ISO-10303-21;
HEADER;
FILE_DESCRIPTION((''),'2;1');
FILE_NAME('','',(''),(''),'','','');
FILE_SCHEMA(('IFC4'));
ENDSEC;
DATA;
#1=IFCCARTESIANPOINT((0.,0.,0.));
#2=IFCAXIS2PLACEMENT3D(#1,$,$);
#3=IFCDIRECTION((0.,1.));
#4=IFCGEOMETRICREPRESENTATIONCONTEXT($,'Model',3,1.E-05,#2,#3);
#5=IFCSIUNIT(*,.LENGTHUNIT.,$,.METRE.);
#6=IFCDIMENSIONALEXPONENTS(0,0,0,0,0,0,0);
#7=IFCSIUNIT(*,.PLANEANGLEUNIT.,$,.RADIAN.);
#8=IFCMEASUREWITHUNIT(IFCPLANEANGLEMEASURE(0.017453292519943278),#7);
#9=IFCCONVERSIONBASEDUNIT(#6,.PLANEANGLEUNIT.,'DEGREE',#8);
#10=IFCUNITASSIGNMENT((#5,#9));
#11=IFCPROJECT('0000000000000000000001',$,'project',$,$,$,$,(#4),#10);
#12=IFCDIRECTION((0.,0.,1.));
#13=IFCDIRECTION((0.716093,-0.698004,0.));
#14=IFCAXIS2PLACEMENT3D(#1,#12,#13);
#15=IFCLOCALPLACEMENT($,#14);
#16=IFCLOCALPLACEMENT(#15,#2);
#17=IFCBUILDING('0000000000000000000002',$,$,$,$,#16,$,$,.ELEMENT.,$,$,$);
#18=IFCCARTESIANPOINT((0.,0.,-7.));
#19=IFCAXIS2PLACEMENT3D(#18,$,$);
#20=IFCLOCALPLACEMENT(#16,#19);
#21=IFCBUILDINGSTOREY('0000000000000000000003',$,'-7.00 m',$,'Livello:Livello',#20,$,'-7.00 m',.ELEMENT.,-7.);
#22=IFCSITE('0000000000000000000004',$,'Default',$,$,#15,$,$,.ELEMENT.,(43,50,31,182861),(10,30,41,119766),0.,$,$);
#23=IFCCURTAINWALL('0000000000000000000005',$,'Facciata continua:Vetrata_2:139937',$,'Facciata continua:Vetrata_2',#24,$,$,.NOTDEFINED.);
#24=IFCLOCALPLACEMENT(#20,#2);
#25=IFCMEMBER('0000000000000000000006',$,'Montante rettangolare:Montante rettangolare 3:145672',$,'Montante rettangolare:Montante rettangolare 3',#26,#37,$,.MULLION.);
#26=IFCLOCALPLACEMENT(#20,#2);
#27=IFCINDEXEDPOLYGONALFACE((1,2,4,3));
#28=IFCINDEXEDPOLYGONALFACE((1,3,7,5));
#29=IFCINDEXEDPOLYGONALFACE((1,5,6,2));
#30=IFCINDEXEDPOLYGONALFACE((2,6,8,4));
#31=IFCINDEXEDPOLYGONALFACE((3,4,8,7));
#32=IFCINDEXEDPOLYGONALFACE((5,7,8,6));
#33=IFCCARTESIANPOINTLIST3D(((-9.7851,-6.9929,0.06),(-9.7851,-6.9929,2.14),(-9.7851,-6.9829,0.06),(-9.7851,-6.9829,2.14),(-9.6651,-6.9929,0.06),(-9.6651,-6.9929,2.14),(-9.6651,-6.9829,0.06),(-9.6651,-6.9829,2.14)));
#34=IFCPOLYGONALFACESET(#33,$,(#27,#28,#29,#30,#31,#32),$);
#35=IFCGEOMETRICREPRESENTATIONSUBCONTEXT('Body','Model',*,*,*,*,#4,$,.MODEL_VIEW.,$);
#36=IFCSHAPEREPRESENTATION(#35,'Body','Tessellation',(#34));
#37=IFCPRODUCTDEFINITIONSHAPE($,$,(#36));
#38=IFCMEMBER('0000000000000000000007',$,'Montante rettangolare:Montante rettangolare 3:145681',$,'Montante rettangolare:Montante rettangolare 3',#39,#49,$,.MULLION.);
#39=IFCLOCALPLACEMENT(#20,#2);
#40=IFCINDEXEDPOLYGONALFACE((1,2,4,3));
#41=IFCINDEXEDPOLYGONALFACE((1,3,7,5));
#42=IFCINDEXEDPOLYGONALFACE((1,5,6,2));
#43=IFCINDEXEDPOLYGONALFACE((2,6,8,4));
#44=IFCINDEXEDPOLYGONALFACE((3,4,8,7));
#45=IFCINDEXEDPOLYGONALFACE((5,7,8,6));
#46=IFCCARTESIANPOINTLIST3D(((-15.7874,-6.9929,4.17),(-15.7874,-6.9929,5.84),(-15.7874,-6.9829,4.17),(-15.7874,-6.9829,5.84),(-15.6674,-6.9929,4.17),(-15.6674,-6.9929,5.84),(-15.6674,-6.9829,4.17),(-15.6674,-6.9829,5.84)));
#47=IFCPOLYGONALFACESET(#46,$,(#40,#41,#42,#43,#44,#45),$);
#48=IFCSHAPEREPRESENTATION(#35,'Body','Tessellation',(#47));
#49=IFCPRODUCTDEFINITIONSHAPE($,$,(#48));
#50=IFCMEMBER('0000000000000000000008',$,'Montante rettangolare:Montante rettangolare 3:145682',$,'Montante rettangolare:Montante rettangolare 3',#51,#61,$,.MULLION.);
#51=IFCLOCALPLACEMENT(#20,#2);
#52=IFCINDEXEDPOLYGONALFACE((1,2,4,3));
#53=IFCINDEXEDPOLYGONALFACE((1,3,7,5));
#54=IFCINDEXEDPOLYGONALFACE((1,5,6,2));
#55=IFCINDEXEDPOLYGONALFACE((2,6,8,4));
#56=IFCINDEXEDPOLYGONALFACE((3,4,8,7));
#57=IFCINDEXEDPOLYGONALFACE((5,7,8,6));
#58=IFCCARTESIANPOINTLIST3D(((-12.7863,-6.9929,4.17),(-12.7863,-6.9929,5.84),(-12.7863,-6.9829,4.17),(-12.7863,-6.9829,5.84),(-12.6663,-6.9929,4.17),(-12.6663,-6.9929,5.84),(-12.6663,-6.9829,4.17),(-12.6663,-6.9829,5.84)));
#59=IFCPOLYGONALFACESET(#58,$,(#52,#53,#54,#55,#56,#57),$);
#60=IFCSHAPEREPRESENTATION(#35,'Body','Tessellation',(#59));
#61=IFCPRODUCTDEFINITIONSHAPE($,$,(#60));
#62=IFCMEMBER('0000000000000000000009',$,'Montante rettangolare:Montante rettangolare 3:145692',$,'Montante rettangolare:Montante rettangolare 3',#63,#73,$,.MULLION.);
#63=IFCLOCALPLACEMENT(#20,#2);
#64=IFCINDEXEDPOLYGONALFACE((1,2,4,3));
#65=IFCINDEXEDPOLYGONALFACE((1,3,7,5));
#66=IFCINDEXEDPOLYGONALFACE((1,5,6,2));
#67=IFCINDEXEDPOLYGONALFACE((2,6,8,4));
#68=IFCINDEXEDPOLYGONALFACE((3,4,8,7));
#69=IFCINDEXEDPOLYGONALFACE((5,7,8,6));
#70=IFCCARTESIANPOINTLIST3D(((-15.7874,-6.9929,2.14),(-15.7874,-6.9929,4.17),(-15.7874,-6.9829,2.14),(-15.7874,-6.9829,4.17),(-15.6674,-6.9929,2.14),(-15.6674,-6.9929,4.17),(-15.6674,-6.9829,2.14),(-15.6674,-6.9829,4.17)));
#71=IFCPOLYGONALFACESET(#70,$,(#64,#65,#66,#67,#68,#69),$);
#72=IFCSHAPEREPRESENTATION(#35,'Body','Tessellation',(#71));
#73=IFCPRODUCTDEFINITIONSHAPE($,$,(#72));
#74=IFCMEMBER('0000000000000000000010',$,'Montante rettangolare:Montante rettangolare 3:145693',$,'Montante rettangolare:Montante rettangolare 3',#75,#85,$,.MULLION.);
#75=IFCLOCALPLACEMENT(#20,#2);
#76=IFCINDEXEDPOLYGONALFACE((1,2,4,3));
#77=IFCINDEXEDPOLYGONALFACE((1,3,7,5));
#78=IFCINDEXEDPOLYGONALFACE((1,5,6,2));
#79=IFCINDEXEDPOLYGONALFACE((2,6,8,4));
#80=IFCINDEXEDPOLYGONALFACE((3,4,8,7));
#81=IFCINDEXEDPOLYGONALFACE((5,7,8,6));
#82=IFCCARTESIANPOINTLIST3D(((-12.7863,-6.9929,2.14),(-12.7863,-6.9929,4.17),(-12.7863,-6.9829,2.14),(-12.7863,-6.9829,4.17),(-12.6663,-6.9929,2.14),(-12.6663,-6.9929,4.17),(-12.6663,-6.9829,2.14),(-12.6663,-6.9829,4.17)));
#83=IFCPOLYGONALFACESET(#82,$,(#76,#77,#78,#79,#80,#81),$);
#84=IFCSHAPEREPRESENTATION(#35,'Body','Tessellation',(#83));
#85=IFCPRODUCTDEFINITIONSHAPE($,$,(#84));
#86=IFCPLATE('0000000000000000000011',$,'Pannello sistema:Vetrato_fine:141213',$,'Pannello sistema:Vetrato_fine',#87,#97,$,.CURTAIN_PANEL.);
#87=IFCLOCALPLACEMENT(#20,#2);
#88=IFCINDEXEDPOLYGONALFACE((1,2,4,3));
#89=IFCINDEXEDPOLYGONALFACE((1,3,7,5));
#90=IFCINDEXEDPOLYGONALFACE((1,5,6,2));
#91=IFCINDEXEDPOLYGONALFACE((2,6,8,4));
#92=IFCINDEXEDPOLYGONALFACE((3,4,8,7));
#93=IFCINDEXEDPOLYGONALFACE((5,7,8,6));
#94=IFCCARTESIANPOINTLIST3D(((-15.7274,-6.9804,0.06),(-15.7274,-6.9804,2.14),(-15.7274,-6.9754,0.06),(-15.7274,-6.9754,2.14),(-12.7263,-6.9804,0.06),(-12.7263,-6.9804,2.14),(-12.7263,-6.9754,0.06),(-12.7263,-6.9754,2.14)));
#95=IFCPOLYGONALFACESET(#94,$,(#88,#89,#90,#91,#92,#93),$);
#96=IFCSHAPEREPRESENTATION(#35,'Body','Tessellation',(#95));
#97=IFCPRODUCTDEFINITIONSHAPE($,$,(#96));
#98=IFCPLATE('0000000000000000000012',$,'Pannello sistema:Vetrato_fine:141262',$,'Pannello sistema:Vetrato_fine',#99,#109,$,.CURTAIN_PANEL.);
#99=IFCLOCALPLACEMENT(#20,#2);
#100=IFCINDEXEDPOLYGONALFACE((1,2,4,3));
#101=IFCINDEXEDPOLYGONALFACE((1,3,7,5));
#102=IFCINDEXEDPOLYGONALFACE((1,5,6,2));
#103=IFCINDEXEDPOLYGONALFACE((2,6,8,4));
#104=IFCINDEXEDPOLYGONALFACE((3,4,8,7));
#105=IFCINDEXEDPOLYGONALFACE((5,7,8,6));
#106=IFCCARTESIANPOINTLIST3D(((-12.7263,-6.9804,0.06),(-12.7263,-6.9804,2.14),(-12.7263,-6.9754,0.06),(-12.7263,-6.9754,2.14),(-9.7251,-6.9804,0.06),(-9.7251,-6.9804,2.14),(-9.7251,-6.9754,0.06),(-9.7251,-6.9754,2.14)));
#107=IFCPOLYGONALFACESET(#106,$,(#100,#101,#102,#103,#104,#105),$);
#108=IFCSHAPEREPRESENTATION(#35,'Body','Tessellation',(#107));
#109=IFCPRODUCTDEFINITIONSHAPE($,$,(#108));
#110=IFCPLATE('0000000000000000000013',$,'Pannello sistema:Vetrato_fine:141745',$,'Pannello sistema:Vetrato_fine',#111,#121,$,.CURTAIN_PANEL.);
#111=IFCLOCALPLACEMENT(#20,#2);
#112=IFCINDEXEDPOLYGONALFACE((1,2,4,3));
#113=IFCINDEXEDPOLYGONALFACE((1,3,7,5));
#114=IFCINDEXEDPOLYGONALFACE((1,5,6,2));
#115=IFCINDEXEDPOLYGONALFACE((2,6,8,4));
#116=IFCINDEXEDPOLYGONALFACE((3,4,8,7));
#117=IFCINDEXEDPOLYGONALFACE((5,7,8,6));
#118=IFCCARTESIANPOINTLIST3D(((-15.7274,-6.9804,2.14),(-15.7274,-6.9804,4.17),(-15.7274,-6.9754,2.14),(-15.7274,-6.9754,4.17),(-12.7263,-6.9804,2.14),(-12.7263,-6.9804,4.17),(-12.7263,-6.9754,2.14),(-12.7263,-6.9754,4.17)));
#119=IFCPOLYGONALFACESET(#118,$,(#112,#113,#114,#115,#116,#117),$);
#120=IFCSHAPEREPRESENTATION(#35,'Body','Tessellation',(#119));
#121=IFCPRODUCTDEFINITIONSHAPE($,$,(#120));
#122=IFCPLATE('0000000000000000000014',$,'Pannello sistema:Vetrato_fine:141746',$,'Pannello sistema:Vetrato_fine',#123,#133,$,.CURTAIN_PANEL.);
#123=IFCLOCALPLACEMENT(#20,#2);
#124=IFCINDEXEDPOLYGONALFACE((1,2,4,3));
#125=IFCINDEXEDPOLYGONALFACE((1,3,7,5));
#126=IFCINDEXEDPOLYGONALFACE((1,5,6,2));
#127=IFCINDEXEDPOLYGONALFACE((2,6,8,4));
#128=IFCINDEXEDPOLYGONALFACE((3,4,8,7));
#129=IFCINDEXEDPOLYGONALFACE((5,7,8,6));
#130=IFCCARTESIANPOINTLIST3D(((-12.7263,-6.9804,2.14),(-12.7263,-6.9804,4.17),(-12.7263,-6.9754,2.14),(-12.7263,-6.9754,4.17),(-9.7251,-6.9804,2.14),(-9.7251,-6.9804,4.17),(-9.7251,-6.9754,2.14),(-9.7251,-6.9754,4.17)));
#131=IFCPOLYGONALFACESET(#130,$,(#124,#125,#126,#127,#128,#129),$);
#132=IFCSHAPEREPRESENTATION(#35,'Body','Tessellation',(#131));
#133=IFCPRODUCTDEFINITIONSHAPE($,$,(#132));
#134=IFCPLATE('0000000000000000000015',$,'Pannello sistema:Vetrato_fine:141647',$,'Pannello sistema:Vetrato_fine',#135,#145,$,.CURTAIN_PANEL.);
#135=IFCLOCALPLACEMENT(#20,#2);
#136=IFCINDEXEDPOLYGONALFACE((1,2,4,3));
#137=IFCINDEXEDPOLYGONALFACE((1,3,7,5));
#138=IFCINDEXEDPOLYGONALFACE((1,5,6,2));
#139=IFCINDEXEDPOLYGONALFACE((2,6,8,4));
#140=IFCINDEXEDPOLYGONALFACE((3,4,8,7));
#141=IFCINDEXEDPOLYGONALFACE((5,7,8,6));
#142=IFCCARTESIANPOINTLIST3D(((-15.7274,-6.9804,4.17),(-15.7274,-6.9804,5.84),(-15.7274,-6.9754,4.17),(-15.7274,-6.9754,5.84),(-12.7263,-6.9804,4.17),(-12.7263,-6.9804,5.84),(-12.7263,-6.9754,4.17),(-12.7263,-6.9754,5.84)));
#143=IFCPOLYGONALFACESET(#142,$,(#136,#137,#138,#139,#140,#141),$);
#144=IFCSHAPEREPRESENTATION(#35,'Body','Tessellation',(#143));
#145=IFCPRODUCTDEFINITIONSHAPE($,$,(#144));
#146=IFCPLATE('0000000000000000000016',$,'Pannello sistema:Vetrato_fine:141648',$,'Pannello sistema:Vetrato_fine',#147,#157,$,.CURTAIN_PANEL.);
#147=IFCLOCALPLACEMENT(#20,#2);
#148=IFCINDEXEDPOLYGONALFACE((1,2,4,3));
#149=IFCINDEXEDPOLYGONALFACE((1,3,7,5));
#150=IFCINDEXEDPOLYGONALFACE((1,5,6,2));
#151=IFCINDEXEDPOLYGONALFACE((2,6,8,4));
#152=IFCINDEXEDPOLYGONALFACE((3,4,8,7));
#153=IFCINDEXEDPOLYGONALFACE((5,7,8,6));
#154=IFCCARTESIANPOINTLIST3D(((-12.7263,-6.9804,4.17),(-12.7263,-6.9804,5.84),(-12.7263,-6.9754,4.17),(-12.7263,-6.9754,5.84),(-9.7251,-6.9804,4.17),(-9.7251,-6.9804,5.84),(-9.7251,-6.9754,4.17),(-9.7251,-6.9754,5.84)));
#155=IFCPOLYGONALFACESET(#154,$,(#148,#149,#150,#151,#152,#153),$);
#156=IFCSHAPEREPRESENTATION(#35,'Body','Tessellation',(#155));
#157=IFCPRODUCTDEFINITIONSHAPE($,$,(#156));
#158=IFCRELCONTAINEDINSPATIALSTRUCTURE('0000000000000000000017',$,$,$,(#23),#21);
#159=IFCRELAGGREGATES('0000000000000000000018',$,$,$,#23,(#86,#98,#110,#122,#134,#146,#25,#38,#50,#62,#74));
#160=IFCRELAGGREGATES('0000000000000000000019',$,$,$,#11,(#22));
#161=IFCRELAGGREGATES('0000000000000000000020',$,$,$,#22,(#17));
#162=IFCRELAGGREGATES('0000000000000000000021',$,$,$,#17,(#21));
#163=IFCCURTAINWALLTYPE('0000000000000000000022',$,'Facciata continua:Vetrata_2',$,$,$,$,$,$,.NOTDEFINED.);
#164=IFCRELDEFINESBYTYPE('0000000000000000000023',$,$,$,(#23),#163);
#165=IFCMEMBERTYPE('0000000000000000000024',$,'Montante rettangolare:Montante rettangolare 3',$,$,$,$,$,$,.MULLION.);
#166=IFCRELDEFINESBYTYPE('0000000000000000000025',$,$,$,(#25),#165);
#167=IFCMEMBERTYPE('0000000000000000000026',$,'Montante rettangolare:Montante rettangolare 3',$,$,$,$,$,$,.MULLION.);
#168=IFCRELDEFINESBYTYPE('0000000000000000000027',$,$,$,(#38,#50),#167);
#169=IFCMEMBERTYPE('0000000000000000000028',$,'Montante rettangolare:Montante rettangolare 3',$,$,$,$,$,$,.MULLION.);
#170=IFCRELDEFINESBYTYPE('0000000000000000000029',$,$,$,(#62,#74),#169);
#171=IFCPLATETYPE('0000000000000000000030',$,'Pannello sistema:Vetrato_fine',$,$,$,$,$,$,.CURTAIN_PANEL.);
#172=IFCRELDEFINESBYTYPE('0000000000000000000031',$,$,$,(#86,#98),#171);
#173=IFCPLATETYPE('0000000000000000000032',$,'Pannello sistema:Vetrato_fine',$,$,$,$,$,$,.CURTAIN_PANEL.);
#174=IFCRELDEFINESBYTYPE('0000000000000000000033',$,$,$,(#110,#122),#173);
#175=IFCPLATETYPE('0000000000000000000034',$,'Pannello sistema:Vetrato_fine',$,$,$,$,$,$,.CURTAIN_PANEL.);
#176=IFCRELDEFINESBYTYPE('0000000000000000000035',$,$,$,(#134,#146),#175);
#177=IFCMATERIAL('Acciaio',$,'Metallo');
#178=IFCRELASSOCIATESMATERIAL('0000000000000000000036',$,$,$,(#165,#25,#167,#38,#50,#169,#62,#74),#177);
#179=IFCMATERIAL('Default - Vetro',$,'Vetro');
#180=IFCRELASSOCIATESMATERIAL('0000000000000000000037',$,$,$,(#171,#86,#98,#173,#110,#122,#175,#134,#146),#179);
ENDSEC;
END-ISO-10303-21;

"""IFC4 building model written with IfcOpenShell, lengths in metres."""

from ifc_helpers import new_model, entity, si_unit, converted_unit, direction, frame, origin, place, context, subcontext, project, spatial, indexed_curve, outline, extrude, source, transform, mapped, material, type_object, type_shapes, element, aggregate, save


model = new_model("IFC4")

# Units and contexts
model_context = context("Model", 3, precision=1e-05, world=origin(), true_north=direction((0.0, 1.0)))
body_context = subcontext(model_context, "Body", "Model", "MODEL_VIEW")
ifc_project = project(units=[si_unit("LENGTHUNIT", "METRE"), converted_unit("PLANEANGLEUNIT", "DEGREE", entity("IfcPlaneAngleMeasure", 0.017453292519943278), si_unit("PLANEANGLEUNIT", "RADIAN"), dimensions=[0, 0, 0, 0, 0, 0, 0])], contexts=[model_context])

# Site, building, storey
site_placement = place(None, frame((0.0, 0.0, 0.0), z_axis=(0.0, 0.0, 1.0), x_axis=(0.716093, -0.698004, 0.0)))
site = spatial("IfcSite", under=ifc_project, at=site_placement, Name="Default", CompositionType="ELEMENT", RefLatitude=(43, 50, 31, 182861), RefLongitude=(10, 30, 41, 119766), RefElevation=0.0)
building_placement = place(site_placement, origin())
building = spatial("IfcBuilding", under=site, at=building_placement, CompositionType="ELEMENT")
storey_placement = place(building_placement, frame((0.0, 0.0, -7.0)))
storey = spatial("IfcBuildingStorey", under=building, at=storey_placement, Name="-7.00 m", ObjectType="Livello:Livello", LongName="-7.00 m", CompositionType="ELEMENT", Elevation=-7.0)

# Curtain wall, members, plates
curtain_wall_type = type_object("IfcCurtainWallType", Name="Facciata continua:Vetrata_2", PredefinedType="NOTDEFINED")
curtain_wall_placement = place(storey_placement, frame((0.0, 0.0, 7.0)))
curtain_wall = element("IfcCurtainWall", 1, at=curtain_wall_placement, inside=storey, type_object=curtain_wall_type, Name="Facciata continua:Vetrata_2:139937", ObjectType="Facciata continua:Vetrata_2", PredefinedType="NOTDEFINED")
ifc_material_1 = material(Name="Acciaio", Category="Metallo")
member_type_1 = type_object("IfcMemberType", Name="Montante rettangolare:Montante rettangolare 3", PredefinedType="MULLION", material=ifc_material_1)
shared_shape_1 = source(origin(), body_context, "Body", "SweptSolid", [
    extrude(outline(indexed_curve([(-0.06, -0.005), (0.06, -0.005), (0.06, 0.005), (-0.06, 0.005), (-0.06, -0.005)], self_intersect=False)), frame((0.0, 0.01, -2.08), z_axis=(0.0, 0.0, 1.0), x_axis=(-1.0, 0.0, 0.0)), (0.0, 0.0, 1.0), 2.08),
])
type_shapes(member_type_1, [shared_shape_1])
member_1_placement = place(curtain_wall_placement, frame((-9.7251, -6.9779, -6.94), z_axis=(0.0, 0.0, -1.0), x_axis=(1.0, 0.0, 0.0)))
member_1 = element("IfcMember", 2, at=member_1_placement, type_object=member_type_1, material=ifc_material_1, Name="Montante rettangolare:Montante rettangolare 3:145672", ObjectType="Montante rettangolare:Montante rettangolare 3", PredefinedType="MULLION", context=body_context, shape_type="MappedRepresentation", body=[
    mapped(shared_shape_1, transform((0.0, 0.0, 0.0), scale=1.0)),
])
member_type_2 = type_object("IfcMemberType", Name="Montante rettangolare:Montante rettangolare 3", PredefinedType="MULLION", material=ifc_material_1)
shared_shape_2 = source(origin(), body_context, "Body", "SweptSolid", [
    extrude(outline(indexed_curve([(-0.06, -0.005), (0.06, -0.005), (0.06, 0.005), (-0.06, 0.005), (-0.06, -0.005)], self_intersect=False)), frame((0.0, 0.01, -1.67), z_axis=(0.0, 0.0, 1.0), x_axis=(-1.0, 0.0, 0.0)), (0.0, 0.0, 1.0), 1.67),
])
type_shapes(member_type_2, [shared_shape_2])
member_2_placement = place(curtain_wall_placement, frame((-15.7274, -6.9779, -2.83), z_axis=(0.0, 0.0, -1.0), x_axis=(1.0, 0.0, 0.0)))
member_2 = element("IfcMember", 3, at=member_2_placement, type_object=member_type_2, material=ifc_material_1, Name="Montante rettangolare:Montante rettangolare 3:145681", ObjectType="Montante rettangolare:Montante rettangolare 3", PredefinedType="MULLION", context=body_context, shape_type="MappedRepresentation", body=[
    mapped(shared_shape_2, transform((0.0, 0.0, 0.0), scale=1.0)),
])
member_3_placement = place(curtain_wall_placement, frame((-12.7263, -6.9779, -2.83), z_axis=(0.0, 0.0, -1.0), x_axis=(1.0, 0.0, 0.0)))
member_3 = element("IfcMember", 4, at=member_3_placement, type_object=member_type_2, material=ifc_material_1, Name="Montante rettangolare:Montante rettangolare 3:145682", ObjectType="Montante rettangolare:Montante rettangolare 3", PredefinedType="MULLION", context=body_context, shape_type="MappedRepresentation", body=[
    mapped(shared_shape_2, transform((0.0, 0.0, 0.0), scale=1.0)),
])
member_type_3 = type_object("IfcMemberType", Name="Montante rettangolare:Montante rettangolare 3", PredefinedType="MULLION", material=ifc_material_1)
shared_shape_3 = source(origin(), body_context, "Body", "SweptSolid", [
    extrude(outline(indexed_curve([(-0.06, -0.005), (0.06, -0.005), (0.06, 0.005), (-0.06, 0.005), (-0.06, -0.005)], self_intersect=False)), frame((0.0, 0.01, -2.03), z_axis=(0.0, 0.0, 1.0), x_axis=(-1.0, 0.0, 0.0)), (0.0, 0.0, 1.0), 2.03),
])
type_shapes(member_type_3, [shared_shape_3])
member_4_placement = place(curtain_wall_placement, frame((-15.7274, -6.9779, -4.86), z_axis=(0.0, 0.0, -1.0), x_axis=(1.0, 0.0, 0.0)))
member_4 = element("IfcMember", 5, at=member_4_placement, type_object=member_type_3, material=ifc_material_1, Name="Montante rettangolare:Montante rettangolare 3:145692", ObjectType="Montante rettangolare:Montante rettangolare 3", PredefinedType="MULLION", context=body_context, shape_type="MappedRepresentation", body=[
    mapped(shared_shape_3, transform((0.0, 0.0, 0.0), scale=1.0)),
])
member_5_placement = place(curtain_wall_placement, frame((-12.7263, -6.9779, -4.86), z_axis=(0.0, 0.0, -1.0), x_axis=(1.0, 0.0, 0.0)))
member_5 = element("IfcMember", 6, at=member_5_placement, type_object=member_type_3, material=ifc_material_1, Name="Montante rettangolare:Montante rettangolare 3:145693", ObjectType="Montante rettangolare:Montante rettangolare 3", PredefinedType="MULLION", context=body_context, shape_type="MappedRepresentation", body=[
    mapped(shared_shape_3, transform((0.0, 0.0, 0.0), scale=1.0)),
])
ifc_material_2 = material(Name="Default - Vetro", Category="Vetro")
plate_type_1 = type_object("IfcPlateType", Name="Pannello sistema:Vetrato_fine", PredefinedType="CURTAIN_PANEL", material=ifc_material_2)
shared_shape_4 = source(origin(), body_context, "Body", "SweptSolid", [
    extrude(outline(indexed_curve([(-0.0025, -1.5006), (0.0025, -1.5006), (0.0025, 1.5006), (-0.0025, 1.5006), (-0.0025, -1.5006)], self_intersect=False)), frame((0.0, 0.0, 0.0), z_axis=(0.0, 0.0, 1.0), x_axis=(0.0, 1.0, 0.0)), (0.0, 0.0, 1.0), 2.08),
])
type_shapes(plate_type_1, [shared_shape_4])
plate_1_placement = place(curtain_wall_placement, frame((-14.2268, -6.9779, -6.94)))
plate_1 = element("IfcPlate", 7, at=plate_1_placement, type_object=plate_type_1, material=ifc_material_2, Name="Pannello sistema:Vetrato_fine:141213", ObjectType="Pannello sistema:Vetrato_fine", PredefinedType="CURTAIN_PANEL", context=body_context, shape_type="MappedRepresentation", body=[
    mapped(shared_shape_4, transform((0.0, 0.0, 0.0), scale=1.0)),
])
plate_2_placement = place(curtain_wall_placement, frame((-11.2257, -6.9779, -6.94)))
plate_2 = element("IfcPlate", 8, at=plate_2_placement, type_object=plate_type_1, material=ifc_material_2, Name="Pannello sistema:Vetrato_fine:141262", ObjectType="Pannello sistema:Vetrato_fine", PredefinedType="CURTAIN_PANEL", context=body_context, shape_type="MappedRepresentation", body=[
    mapped(shared_shape_4, transform((0.0, 0.0, 0.0), scale=1.0)),
])
plate_type_2 = type_object("IfcPlateType", Name="Pannello sistema:Vetrato_fine", PredefinedType="CURTAIN_PANEL", material=ifc_material_2)
shared_shape_5 = source(origin(), body_context, "Body", "SweptSolid", [
    extrude(outline(indexed_curve([(-0.0025, -1.5006), (0.0025, -1.5006), (0.0025, 1.5006), (-0.0025, 1.5006), (-0.0025, -1.5006)], self_intersect=False)), frame((0.0, 0.0, 0.0), z_axis=(0.0, 0.0, 1.0), x_axis=(0.0, 1.0, 0.0)), (0.0, 0.0, 1.0), 2.03),
])
type_shapes(plate_type_2, [shared_shape_5])
plate_3_placement = place(curtain_wall_placement, frame((-14.2268, -6.9779, -4.86)))
plate_3 = element("IfcPlate", 9, at=plate_3_placement, type_object=plate_type_2, material=ifc_material_2, Name="Pannello sistema:Vetrato_fine:141745", ObjectType="Pannello sistema:Vetrato_fine", PredefinedType="CURTAIN_PANEL", context=body_context, shape_type="MappedRepresentation", body=[
    mapped(shared_shape_5, transform((0.0, 0.0, 0.0), scale=1.0)),
])
plate_4_placement = place(curtain_wall_placement, frame((-11.2257, -6.9779, -4.86)))
plate_4 = element("IfcPlate", 10, at=plate_4_placement, type_object=plate_type_2, material=ifc_material_2, Name="Pannello sistema:Vetrato_fine:141746", ObjectType="Pannello sistema:Vetrato_fine", PredefinedType="CURTAIN_PANEL", context=body_context, shape_type="MappedRepresentation", body=[
    mapped(shared_shape_5, transform((0.0, 0.0, 0.0), scale=1.0)),
])
plate_type_3 = type_object("IfcPlateType", Name="Pannello sistema:Vetrato_fine", PredefinedType="CURTAIN_PANEL", material=ifc_material_2)
shared_shape_6 = source(origin(), body_context, "Body", "SweptSolid", [
    extrude(outline(indexed_curve([(-0.0025, -1.5006), (0.0025, -1.5006), (0.0025, 1.5006), (-0.0025, 1.5006), (-0.0025, -1.5006)], self_intersect=False)), frame((0.0, 0.0, 0.0), z_axis=(0.0, 0.0, 1.0), x_axis=(0.0, 1.0, 0.0)), (0.0, 0.0, 1.0), 1.67),
])
type_shapes(plate_type_3, [shared_shape_6])
plate_5_placement = place(curtain_wall_placement, frame((-14.2268, -6.9779, -2.83)))
plate_5 = element("IfcPlate", 11, at=plate_5_placement, type_object=plate_type_3, material=ifc_material_2, Name="Pannello sistema:Vetrato_fine:141647", ObjectType="Pannello sistema:Vetrato_fine", PredefinedType="CURTAIN_PANEL", context=body_context, shape_type="MappedRepresentation", body=[
    mapped(shared_shape_6, transform((0.0, 0.0, 0.0), scale=1.0)),
])
plate_6_placement = place(curtain_wall_placement, frame((-11.2257, -6.9779, -2.83)))
plate_6 = element("IfcPlate", 12, at=plate_6_placement, type_object=plate_type_3, material=ifc_material_2, Name="Pannello sistema:Vetrato_fine:141648", ObjectType="Pannello sistema:Vetrato_fine", PredefinedType="CURTAIN_PANEL", context=body_context, shape_type="MappedRepresentation", body=[
    mapped(shared_shape_6, transform((0.0, 0.0, 0.0), scale=1.0)),
])
aggregate(curtain_wall, [plate_1, plate_2, plate_3, plate_4, plate_5, plate_6, member_1, member_2, member_3, member_4, member_5])

save(model, "model.ifc")
